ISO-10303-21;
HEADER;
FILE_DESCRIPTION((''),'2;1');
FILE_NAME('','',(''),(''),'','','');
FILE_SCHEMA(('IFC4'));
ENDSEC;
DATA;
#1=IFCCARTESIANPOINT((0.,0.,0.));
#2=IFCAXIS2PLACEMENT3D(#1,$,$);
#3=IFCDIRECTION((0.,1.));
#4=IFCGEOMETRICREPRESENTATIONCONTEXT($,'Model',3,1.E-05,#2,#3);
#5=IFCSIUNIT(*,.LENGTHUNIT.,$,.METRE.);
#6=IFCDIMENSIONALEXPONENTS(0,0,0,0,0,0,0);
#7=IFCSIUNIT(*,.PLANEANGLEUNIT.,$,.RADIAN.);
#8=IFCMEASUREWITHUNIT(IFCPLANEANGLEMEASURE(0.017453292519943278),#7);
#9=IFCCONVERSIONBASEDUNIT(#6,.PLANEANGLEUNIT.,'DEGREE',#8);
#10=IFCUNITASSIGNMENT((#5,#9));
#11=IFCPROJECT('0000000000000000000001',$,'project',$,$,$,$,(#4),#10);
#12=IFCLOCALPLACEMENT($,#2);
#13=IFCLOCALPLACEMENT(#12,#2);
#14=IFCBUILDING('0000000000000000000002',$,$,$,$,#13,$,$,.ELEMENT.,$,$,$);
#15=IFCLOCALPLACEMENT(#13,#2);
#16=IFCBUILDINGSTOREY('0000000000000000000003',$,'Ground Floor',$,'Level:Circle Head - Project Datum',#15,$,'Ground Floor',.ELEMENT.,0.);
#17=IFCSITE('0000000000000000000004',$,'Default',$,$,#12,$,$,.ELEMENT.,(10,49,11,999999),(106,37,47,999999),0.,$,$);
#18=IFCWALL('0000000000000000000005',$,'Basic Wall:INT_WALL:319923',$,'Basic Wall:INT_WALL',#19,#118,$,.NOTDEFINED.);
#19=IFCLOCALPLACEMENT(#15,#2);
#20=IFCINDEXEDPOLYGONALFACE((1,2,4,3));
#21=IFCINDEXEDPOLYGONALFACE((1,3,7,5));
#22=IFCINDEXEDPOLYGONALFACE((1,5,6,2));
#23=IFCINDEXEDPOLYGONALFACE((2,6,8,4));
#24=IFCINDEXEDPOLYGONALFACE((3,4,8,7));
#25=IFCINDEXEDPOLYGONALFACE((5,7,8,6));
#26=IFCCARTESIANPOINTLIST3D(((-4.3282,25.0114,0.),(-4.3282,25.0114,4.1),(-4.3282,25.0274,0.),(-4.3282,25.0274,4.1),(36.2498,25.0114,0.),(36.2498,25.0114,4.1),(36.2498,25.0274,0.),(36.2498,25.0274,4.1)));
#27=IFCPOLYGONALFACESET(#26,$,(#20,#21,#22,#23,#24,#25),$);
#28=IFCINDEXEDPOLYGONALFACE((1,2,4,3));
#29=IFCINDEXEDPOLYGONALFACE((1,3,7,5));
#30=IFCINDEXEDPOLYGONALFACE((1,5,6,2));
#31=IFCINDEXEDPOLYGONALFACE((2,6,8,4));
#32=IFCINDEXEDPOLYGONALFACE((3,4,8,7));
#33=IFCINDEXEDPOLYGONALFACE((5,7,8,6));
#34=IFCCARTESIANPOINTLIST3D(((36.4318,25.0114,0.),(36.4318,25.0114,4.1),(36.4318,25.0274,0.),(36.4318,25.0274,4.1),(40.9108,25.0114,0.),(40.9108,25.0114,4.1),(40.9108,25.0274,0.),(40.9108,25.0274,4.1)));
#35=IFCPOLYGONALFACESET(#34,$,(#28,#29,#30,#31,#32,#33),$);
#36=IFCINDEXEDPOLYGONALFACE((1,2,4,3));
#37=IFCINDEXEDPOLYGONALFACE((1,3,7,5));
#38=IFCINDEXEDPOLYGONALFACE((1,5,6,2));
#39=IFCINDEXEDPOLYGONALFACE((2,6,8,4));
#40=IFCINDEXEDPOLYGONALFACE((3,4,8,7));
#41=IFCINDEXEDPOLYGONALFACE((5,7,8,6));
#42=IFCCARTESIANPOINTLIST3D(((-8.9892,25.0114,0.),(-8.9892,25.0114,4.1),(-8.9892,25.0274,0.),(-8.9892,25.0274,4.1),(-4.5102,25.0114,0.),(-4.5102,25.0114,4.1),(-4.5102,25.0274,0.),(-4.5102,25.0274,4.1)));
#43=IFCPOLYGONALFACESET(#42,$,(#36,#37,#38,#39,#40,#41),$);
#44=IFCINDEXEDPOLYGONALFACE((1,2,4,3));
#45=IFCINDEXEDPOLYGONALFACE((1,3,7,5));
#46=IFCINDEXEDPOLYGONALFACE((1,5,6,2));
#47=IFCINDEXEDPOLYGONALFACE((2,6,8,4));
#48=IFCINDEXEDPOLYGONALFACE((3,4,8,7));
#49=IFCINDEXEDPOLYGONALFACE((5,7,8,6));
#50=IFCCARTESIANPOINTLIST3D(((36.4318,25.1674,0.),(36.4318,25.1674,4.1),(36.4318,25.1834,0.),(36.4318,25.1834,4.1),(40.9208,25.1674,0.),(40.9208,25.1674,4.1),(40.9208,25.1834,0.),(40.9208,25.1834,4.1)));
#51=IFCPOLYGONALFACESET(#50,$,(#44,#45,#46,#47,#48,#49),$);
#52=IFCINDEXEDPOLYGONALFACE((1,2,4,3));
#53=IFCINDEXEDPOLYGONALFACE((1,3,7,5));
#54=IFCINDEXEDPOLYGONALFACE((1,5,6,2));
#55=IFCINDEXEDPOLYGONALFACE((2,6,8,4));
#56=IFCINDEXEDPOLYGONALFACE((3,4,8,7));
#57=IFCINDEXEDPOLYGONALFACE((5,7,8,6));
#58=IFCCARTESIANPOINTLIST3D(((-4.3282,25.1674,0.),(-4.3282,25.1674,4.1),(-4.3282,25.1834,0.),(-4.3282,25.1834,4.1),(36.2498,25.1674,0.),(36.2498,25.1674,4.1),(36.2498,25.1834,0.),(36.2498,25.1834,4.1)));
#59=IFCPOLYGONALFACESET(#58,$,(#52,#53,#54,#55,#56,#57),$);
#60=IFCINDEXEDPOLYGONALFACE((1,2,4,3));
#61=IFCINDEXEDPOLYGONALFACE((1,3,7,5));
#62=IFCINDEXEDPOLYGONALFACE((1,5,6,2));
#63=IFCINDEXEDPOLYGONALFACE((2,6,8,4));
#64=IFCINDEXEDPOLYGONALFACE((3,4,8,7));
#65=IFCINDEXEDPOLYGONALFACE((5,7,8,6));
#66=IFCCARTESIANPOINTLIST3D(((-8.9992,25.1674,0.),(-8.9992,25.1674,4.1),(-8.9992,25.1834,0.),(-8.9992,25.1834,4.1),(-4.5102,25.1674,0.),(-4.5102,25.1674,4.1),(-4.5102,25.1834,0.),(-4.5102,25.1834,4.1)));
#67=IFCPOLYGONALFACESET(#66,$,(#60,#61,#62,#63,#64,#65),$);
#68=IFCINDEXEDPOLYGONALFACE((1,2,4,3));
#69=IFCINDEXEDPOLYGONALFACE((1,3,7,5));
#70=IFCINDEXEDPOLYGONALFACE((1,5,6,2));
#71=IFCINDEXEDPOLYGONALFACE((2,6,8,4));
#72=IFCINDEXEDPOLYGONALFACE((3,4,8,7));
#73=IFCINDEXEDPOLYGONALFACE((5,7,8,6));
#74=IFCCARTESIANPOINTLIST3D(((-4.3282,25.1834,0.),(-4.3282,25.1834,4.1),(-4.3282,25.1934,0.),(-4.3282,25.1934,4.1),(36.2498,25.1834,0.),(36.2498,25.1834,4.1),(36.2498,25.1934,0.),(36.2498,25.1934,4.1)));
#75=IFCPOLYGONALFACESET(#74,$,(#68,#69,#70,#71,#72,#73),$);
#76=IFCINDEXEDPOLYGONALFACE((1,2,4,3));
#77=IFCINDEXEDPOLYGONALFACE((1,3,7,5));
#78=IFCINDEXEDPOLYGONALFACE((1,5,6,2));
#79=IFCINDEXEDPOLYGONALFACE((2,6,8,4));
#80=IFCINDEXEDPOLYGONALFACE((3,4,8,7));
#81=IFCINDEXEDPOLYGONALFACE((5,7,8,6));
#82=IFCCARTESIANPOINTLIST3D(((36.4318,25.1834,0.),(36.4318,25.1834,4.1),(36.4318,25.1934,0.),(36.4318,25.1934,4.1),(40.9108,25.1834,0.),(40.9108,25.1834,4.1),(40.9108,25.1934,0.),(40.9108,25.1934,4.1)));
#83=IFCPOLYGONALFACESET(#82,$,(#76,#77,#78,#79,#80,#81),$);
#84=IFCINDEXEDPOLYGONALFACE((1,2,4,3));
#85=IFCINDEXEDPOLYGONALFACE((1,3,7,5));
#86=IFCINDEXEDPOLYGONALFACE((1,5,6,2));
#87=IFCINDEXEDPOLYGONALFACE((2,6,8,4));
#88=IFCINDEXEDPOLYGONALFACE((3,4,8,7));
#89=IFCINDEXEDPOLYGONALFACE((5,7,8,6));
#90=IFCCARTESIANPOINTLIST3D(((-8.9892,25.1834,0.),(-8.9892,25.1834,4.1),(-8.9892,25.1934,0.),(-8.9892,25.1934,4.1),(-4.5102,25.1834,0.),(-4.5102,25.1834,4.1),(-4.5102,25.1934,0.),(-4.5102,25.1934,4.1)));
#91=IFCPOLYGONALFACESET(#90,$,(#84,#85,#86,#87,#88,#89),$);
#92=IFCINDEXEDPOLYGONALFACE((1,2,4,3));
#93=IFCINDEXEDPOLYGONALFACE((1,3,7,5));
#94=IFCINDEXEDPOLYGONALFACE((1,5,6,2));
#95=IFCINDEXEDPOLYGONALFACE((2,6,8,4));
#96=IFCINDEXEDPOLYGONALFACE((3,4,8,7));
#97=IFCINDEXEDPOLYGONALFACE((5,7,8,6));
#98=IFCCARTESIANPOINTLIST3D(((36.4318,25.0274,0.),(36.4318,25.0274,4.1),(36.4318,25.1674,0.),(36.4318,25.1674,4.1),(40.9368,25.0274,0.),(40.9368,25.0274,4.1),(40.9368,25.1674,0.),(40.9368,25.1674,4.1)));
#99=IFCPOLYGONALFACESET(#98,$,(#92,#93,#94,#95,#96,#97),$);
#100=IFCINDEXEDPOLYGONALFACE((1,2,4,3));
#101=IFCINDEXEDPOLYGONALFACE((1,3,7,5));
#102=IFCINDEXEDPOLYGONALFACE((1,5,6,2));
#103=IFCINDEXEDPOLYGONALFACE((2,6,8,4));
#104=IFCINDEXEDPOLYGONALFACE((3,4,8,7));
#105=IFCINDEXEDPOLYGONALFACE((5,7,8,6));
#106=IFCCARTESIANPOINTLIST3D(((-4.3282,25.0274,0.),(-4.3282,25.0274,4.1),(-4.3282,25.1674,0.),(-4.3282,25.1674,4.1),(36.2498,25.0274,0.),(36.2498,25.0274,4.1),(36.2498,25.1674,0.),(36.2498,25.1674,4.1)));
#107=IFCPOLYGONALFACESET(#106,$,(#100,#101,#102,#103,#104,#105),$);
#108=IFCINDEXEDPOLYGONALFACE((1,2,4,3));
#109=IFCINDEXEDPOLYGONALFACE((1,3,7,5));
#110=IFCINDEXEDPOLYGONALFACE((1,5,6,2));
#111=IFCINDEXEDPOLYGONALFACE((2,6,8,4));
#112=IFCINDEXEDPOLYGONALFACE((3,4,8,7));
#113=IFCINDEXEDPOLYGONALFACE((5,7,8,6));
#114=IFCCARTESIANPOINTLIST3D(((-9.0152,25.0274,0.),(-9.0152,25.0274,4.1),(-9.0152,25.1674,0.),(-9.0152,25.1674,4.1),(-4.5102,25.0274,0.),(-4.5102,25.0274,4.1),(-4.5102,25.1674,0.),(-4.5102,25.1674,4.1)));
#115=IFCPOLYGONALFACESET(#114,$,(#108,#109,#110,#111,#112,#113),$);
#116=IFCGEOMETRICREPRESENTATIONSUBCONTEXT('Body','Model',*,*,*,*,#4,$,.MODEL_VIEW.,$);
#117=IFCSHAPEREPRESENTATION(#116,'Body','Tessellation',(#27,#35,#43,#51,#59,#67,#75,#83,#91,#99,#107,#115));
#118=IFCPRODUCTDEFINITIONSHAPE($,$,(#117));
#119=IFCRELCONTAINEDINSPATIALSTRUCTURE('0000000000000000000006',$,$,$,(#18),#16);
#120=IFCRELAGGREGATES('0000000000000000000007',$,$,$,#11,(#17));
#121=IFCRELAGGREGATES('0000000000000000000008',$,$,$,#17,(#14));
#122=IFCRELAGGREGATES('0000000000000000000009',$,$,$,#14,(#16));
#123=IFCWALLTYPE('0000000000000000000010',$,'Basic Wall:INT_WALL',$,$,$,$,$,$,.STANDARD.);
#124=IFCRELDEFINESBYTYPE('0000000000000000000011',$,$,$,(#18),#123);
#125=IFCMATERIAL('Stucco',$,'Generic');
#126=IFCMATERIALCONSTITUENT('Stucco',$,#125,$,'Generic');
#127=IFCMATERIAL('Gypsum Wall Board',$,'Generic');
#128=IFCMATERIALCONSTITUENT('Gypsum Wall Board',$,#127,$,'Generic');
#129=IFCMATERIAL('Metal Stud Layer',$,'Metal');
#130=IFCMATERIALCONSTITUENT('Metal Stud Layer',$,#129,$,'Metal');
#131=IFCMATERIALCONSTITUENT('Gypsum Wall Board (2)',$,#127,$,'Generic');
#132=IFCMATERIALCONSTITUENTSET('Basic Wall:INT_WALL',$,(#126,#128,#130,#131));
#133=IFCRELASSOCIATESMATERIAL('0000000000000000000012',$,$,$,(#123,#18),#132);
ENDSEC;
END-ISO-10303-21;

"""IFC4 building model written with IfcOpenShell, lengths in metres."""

from ifc_helpers import new_model, entity, si_unit, converted_unit, direction, frame, origin, place, context, subcontext, project, spatial, indexed_curve, outline, extrude, material, constituent, constituent_set, type_object, element, save


model = new_model("IFC4")

# Units and contexts
model_context = context("Model", 3, precision=1e-05, world=origin(), true_north=direction((0.0, 1.0)))
body_context = subcontext(model_context, "Body", "Model", "MODEL_VIEW")
ifc_project = project(units=[si_unit("LENGTHUNIT", "METRE"), converted_unit("PLANEANGLEUNIT", "DEGREE", entity("IfcPlaneAngleMeasure", 0.017453292519943278), si_unit("PLANEANGLEUNIT", "RADIAN"), dimensions=[0, 0, 0, 0, 0, 0, 0])], contexts=[model_context])

# Site, building, storey
site_placement = place(None, origin())
site = spatial("IfcSite", under=ifc_project, at=site_placement, Name="Default", CompositionType="ELEMENT", RefLatitude=(10, 49, 11, 999999), RefLongitude=(106, 37, 47, 999999), RefElevation=0.0)
building_placement = place(site_placement, origin())
building = spatial("IfcBuilding", under=site, at=building_placement, CompositionType="ELEMENT")
storey_placement = place(building_placement, origin())
storey = spatial("IfcBuildingStorey", under=building, at=storey_placement, Name="Ground Floor", ObjectType="Level:Circle Head - Project Datum", LongName="Ground Floor", CompositionType="ELEMENT", Elevation=0.0)

# Shared definitions
ifc_material_1 = material(Name="Stucco", Category="Generic")
ifc_material_2 = material(Name="Gypsum Wall Board", Category="Generic")
ifc_material_3 = material(Name="Metal Stud Layer", Category="Metal")

# Wall
ifc_constituent_1 = constituent(ifc_material_1, Name="Stucco", Category="Generic")
ifc_constituent_2 = constituent(ifc_material_2, Name="Gypsum Wall Board", Category="Generic")
ifc_constituent_3 = constituent(ifc_material_3, Name="Metal Stud Layer", Category="Metal")
ifc_constituent_4 = constituent(ifc_material_2, Name="Gypsum Wall Board (2)", Category="Generic")
ifc_constituent_set_1 = constituent_set(constituents=[ifc_constituent_1, ifc_constituent_2, ifc_constituent_3, ifc_constituent_4], Name="Basic Wall:INT_WALL")
wall_type_1 = type_object("IfcWallType", Name="Basic Wall:INT_WALL", PredefinedType="STANDARD", material=ifc_constituent_set_1)
wall_1_placement = place(storey_placement, frame((-8.9892, 25.1024, 0.0)))
element("IfcWall", 1, at=wall_1_placement, inside=storey, type_object=wall_type_1, material=ifc_constituent_set_1, Name="Basic Wall:INT_WALL:319923", ObjectType="Basic Wall:INT_WALL", PredefinedType="NOTDEFINED", context=body_context, shape_type="SweptSolid", body=[
    extrude(outline(indexed_curve([(-0.008, -20.289), (0.008, -20.289), (0.008, 20.289), (-0.008, 20.289), (-0.008, -20.289)], self_intersect=False)), frame((24.95, -0.083, 0.0), z_axis=(0.0, 0.0, 1.0), x_axis=(0.0, 1.0, 0.0)), (0.0, 0.0, 1.0), 4.1),
    extrude(outline(indexed_curve([(-0.008, -2.2395), (0.008, -2.2395), (0.008, 2.2395), (-0.008, 2.2395), (-0.008, -2.2395)], self_intersect=False)), frame((47.6605, -0.083, 0.0), z_axis=(0.0, 0.0, 1.0), x_axis=(0.0, 1.0, 0.0)), (0.0, 0.0, 1.0), 4.1),
    extrude(outline(indexed_curve([(-0.008, -2.2395), (0.008, -2.2395), (0.008, 2.2395), (-0.008, 2.2395), (-0.008, -2.2395)], self_intersect=False)), frame((2.2395, -0.083, 0.0), z_axis=(0.0, 0.0, 1.0), x_axis=(0.0, 1.0, 0.0)), (0.0, 0.0, 1.0), 4.1),
    extrude(outline(indexed_curve([(-2.2445, -0.008), (2.2445, -0.008), (2.2445, 0.008), (-2.2445, 0.008), (-2.2445, -0.008)], self_intersect=False)), frame((47.6655, 0.073, 0.0), z_axis=(0.0, 0.0, 1.0), x_axis=(-1.0, 0.0, 0.0)), (0.0, 0.0, 1.0), 4.1),
    extrude(outline(indexed_curve([(-20.289, -0.008), (20.289, -0.008), (20.289, 0.008), (-20.289, 0.008), (-20.289, -0.008)], self_intersect=False)), frame((24.95, 0.073, 0.0)), (0.0, 0.0, 1.0), 4.1),
    extrude(outline(indexed_curve([(-2.2445, -0.008), (2.2445, -0.008), (2.2445, 0.008), (-2.2445, 0.008), (-2.2445, -0.008)], self_intersect=False)), frame((2.2345, 0.073, 0.0)), (0.0, 0.0, 1.0), 4.1),
    extrude(outline(indexed_curve([(-0.005, -20.289), (0.005, -20.289), (0.005, 20.289), (-0.005, 20.289), (-0.005, -20.289)], self_intersect=False)), frame((24.95, 0.086, 0.0), z_axis=(0.0, 0.0, 1.0), x_axis=(0.0, -1.0, 0.0)), (0.0, 0.0, 1.0), 4.1),
    extrude(outline(indexed_curve([(-0.005, -2.2395), (0.005, -2.2395), (0.005, 2.2395), (-0.005, 2.2395), (-0.005, -2.2395)], self_intersect=False)), frame((47.6605, 0.086, 0.0), z_axis=(0.0, 0.0, 1.0), x_axis=(0.0, -1.0, 0.0)), (0.0, 0.0, 1.0), 4.1),
    extrude(outline(indexed_curve([(-0.005, -2.2395), (0.005, -2.2395), (0.005, 2.2395), (-0.005, 2.2395), (-0.005, -2.2395)], self_intersect=False)), frame((2.2395, 0.086, 0.0), z_axis=(0.0, 0.0, 1.0), x_axis=(0.0, -1.0, 0.0)), (0.0, 0.0, 1.0), 4.1),
    extrude(outline(indexed_curve([(-2.2525, -0.07), (2.2525, -0.07), (2.2525, 0.07), (-2.2525, 0.07), (-2.2525, -0.07)], self_intersect=False)), frame((47.6735, -0.005, 0.0), z_axis=(0.0, 0.0, 1.0), x_axis=(-1.0, 0.0, 0.0)), (0.0, 0.0, 1.0), 4.1),
    extrude(outline(indexed_curve([(-20.289, -0.07), (20.289, -0.07), (20.289, 0.07), (-20.289, 0.07), (-20.289, -0.07)], self_intersect=False)), frame((24.95, -0.005, 0.0)), (0.0, 0.0, 1.0), 4.1),
    extrude(outline(indexed_curve([(-2.2525, -0.07), (2.2525, -0.07), (2.2525, 0.07), (-2.2525, 0.07), (-2.2525, -0.07)], self_intersect=False)), frame((2.2265, -0.005, 0.0)), (0.0, 0.0, 1.0), 4.1),
])

save(model, "model.ifc")
